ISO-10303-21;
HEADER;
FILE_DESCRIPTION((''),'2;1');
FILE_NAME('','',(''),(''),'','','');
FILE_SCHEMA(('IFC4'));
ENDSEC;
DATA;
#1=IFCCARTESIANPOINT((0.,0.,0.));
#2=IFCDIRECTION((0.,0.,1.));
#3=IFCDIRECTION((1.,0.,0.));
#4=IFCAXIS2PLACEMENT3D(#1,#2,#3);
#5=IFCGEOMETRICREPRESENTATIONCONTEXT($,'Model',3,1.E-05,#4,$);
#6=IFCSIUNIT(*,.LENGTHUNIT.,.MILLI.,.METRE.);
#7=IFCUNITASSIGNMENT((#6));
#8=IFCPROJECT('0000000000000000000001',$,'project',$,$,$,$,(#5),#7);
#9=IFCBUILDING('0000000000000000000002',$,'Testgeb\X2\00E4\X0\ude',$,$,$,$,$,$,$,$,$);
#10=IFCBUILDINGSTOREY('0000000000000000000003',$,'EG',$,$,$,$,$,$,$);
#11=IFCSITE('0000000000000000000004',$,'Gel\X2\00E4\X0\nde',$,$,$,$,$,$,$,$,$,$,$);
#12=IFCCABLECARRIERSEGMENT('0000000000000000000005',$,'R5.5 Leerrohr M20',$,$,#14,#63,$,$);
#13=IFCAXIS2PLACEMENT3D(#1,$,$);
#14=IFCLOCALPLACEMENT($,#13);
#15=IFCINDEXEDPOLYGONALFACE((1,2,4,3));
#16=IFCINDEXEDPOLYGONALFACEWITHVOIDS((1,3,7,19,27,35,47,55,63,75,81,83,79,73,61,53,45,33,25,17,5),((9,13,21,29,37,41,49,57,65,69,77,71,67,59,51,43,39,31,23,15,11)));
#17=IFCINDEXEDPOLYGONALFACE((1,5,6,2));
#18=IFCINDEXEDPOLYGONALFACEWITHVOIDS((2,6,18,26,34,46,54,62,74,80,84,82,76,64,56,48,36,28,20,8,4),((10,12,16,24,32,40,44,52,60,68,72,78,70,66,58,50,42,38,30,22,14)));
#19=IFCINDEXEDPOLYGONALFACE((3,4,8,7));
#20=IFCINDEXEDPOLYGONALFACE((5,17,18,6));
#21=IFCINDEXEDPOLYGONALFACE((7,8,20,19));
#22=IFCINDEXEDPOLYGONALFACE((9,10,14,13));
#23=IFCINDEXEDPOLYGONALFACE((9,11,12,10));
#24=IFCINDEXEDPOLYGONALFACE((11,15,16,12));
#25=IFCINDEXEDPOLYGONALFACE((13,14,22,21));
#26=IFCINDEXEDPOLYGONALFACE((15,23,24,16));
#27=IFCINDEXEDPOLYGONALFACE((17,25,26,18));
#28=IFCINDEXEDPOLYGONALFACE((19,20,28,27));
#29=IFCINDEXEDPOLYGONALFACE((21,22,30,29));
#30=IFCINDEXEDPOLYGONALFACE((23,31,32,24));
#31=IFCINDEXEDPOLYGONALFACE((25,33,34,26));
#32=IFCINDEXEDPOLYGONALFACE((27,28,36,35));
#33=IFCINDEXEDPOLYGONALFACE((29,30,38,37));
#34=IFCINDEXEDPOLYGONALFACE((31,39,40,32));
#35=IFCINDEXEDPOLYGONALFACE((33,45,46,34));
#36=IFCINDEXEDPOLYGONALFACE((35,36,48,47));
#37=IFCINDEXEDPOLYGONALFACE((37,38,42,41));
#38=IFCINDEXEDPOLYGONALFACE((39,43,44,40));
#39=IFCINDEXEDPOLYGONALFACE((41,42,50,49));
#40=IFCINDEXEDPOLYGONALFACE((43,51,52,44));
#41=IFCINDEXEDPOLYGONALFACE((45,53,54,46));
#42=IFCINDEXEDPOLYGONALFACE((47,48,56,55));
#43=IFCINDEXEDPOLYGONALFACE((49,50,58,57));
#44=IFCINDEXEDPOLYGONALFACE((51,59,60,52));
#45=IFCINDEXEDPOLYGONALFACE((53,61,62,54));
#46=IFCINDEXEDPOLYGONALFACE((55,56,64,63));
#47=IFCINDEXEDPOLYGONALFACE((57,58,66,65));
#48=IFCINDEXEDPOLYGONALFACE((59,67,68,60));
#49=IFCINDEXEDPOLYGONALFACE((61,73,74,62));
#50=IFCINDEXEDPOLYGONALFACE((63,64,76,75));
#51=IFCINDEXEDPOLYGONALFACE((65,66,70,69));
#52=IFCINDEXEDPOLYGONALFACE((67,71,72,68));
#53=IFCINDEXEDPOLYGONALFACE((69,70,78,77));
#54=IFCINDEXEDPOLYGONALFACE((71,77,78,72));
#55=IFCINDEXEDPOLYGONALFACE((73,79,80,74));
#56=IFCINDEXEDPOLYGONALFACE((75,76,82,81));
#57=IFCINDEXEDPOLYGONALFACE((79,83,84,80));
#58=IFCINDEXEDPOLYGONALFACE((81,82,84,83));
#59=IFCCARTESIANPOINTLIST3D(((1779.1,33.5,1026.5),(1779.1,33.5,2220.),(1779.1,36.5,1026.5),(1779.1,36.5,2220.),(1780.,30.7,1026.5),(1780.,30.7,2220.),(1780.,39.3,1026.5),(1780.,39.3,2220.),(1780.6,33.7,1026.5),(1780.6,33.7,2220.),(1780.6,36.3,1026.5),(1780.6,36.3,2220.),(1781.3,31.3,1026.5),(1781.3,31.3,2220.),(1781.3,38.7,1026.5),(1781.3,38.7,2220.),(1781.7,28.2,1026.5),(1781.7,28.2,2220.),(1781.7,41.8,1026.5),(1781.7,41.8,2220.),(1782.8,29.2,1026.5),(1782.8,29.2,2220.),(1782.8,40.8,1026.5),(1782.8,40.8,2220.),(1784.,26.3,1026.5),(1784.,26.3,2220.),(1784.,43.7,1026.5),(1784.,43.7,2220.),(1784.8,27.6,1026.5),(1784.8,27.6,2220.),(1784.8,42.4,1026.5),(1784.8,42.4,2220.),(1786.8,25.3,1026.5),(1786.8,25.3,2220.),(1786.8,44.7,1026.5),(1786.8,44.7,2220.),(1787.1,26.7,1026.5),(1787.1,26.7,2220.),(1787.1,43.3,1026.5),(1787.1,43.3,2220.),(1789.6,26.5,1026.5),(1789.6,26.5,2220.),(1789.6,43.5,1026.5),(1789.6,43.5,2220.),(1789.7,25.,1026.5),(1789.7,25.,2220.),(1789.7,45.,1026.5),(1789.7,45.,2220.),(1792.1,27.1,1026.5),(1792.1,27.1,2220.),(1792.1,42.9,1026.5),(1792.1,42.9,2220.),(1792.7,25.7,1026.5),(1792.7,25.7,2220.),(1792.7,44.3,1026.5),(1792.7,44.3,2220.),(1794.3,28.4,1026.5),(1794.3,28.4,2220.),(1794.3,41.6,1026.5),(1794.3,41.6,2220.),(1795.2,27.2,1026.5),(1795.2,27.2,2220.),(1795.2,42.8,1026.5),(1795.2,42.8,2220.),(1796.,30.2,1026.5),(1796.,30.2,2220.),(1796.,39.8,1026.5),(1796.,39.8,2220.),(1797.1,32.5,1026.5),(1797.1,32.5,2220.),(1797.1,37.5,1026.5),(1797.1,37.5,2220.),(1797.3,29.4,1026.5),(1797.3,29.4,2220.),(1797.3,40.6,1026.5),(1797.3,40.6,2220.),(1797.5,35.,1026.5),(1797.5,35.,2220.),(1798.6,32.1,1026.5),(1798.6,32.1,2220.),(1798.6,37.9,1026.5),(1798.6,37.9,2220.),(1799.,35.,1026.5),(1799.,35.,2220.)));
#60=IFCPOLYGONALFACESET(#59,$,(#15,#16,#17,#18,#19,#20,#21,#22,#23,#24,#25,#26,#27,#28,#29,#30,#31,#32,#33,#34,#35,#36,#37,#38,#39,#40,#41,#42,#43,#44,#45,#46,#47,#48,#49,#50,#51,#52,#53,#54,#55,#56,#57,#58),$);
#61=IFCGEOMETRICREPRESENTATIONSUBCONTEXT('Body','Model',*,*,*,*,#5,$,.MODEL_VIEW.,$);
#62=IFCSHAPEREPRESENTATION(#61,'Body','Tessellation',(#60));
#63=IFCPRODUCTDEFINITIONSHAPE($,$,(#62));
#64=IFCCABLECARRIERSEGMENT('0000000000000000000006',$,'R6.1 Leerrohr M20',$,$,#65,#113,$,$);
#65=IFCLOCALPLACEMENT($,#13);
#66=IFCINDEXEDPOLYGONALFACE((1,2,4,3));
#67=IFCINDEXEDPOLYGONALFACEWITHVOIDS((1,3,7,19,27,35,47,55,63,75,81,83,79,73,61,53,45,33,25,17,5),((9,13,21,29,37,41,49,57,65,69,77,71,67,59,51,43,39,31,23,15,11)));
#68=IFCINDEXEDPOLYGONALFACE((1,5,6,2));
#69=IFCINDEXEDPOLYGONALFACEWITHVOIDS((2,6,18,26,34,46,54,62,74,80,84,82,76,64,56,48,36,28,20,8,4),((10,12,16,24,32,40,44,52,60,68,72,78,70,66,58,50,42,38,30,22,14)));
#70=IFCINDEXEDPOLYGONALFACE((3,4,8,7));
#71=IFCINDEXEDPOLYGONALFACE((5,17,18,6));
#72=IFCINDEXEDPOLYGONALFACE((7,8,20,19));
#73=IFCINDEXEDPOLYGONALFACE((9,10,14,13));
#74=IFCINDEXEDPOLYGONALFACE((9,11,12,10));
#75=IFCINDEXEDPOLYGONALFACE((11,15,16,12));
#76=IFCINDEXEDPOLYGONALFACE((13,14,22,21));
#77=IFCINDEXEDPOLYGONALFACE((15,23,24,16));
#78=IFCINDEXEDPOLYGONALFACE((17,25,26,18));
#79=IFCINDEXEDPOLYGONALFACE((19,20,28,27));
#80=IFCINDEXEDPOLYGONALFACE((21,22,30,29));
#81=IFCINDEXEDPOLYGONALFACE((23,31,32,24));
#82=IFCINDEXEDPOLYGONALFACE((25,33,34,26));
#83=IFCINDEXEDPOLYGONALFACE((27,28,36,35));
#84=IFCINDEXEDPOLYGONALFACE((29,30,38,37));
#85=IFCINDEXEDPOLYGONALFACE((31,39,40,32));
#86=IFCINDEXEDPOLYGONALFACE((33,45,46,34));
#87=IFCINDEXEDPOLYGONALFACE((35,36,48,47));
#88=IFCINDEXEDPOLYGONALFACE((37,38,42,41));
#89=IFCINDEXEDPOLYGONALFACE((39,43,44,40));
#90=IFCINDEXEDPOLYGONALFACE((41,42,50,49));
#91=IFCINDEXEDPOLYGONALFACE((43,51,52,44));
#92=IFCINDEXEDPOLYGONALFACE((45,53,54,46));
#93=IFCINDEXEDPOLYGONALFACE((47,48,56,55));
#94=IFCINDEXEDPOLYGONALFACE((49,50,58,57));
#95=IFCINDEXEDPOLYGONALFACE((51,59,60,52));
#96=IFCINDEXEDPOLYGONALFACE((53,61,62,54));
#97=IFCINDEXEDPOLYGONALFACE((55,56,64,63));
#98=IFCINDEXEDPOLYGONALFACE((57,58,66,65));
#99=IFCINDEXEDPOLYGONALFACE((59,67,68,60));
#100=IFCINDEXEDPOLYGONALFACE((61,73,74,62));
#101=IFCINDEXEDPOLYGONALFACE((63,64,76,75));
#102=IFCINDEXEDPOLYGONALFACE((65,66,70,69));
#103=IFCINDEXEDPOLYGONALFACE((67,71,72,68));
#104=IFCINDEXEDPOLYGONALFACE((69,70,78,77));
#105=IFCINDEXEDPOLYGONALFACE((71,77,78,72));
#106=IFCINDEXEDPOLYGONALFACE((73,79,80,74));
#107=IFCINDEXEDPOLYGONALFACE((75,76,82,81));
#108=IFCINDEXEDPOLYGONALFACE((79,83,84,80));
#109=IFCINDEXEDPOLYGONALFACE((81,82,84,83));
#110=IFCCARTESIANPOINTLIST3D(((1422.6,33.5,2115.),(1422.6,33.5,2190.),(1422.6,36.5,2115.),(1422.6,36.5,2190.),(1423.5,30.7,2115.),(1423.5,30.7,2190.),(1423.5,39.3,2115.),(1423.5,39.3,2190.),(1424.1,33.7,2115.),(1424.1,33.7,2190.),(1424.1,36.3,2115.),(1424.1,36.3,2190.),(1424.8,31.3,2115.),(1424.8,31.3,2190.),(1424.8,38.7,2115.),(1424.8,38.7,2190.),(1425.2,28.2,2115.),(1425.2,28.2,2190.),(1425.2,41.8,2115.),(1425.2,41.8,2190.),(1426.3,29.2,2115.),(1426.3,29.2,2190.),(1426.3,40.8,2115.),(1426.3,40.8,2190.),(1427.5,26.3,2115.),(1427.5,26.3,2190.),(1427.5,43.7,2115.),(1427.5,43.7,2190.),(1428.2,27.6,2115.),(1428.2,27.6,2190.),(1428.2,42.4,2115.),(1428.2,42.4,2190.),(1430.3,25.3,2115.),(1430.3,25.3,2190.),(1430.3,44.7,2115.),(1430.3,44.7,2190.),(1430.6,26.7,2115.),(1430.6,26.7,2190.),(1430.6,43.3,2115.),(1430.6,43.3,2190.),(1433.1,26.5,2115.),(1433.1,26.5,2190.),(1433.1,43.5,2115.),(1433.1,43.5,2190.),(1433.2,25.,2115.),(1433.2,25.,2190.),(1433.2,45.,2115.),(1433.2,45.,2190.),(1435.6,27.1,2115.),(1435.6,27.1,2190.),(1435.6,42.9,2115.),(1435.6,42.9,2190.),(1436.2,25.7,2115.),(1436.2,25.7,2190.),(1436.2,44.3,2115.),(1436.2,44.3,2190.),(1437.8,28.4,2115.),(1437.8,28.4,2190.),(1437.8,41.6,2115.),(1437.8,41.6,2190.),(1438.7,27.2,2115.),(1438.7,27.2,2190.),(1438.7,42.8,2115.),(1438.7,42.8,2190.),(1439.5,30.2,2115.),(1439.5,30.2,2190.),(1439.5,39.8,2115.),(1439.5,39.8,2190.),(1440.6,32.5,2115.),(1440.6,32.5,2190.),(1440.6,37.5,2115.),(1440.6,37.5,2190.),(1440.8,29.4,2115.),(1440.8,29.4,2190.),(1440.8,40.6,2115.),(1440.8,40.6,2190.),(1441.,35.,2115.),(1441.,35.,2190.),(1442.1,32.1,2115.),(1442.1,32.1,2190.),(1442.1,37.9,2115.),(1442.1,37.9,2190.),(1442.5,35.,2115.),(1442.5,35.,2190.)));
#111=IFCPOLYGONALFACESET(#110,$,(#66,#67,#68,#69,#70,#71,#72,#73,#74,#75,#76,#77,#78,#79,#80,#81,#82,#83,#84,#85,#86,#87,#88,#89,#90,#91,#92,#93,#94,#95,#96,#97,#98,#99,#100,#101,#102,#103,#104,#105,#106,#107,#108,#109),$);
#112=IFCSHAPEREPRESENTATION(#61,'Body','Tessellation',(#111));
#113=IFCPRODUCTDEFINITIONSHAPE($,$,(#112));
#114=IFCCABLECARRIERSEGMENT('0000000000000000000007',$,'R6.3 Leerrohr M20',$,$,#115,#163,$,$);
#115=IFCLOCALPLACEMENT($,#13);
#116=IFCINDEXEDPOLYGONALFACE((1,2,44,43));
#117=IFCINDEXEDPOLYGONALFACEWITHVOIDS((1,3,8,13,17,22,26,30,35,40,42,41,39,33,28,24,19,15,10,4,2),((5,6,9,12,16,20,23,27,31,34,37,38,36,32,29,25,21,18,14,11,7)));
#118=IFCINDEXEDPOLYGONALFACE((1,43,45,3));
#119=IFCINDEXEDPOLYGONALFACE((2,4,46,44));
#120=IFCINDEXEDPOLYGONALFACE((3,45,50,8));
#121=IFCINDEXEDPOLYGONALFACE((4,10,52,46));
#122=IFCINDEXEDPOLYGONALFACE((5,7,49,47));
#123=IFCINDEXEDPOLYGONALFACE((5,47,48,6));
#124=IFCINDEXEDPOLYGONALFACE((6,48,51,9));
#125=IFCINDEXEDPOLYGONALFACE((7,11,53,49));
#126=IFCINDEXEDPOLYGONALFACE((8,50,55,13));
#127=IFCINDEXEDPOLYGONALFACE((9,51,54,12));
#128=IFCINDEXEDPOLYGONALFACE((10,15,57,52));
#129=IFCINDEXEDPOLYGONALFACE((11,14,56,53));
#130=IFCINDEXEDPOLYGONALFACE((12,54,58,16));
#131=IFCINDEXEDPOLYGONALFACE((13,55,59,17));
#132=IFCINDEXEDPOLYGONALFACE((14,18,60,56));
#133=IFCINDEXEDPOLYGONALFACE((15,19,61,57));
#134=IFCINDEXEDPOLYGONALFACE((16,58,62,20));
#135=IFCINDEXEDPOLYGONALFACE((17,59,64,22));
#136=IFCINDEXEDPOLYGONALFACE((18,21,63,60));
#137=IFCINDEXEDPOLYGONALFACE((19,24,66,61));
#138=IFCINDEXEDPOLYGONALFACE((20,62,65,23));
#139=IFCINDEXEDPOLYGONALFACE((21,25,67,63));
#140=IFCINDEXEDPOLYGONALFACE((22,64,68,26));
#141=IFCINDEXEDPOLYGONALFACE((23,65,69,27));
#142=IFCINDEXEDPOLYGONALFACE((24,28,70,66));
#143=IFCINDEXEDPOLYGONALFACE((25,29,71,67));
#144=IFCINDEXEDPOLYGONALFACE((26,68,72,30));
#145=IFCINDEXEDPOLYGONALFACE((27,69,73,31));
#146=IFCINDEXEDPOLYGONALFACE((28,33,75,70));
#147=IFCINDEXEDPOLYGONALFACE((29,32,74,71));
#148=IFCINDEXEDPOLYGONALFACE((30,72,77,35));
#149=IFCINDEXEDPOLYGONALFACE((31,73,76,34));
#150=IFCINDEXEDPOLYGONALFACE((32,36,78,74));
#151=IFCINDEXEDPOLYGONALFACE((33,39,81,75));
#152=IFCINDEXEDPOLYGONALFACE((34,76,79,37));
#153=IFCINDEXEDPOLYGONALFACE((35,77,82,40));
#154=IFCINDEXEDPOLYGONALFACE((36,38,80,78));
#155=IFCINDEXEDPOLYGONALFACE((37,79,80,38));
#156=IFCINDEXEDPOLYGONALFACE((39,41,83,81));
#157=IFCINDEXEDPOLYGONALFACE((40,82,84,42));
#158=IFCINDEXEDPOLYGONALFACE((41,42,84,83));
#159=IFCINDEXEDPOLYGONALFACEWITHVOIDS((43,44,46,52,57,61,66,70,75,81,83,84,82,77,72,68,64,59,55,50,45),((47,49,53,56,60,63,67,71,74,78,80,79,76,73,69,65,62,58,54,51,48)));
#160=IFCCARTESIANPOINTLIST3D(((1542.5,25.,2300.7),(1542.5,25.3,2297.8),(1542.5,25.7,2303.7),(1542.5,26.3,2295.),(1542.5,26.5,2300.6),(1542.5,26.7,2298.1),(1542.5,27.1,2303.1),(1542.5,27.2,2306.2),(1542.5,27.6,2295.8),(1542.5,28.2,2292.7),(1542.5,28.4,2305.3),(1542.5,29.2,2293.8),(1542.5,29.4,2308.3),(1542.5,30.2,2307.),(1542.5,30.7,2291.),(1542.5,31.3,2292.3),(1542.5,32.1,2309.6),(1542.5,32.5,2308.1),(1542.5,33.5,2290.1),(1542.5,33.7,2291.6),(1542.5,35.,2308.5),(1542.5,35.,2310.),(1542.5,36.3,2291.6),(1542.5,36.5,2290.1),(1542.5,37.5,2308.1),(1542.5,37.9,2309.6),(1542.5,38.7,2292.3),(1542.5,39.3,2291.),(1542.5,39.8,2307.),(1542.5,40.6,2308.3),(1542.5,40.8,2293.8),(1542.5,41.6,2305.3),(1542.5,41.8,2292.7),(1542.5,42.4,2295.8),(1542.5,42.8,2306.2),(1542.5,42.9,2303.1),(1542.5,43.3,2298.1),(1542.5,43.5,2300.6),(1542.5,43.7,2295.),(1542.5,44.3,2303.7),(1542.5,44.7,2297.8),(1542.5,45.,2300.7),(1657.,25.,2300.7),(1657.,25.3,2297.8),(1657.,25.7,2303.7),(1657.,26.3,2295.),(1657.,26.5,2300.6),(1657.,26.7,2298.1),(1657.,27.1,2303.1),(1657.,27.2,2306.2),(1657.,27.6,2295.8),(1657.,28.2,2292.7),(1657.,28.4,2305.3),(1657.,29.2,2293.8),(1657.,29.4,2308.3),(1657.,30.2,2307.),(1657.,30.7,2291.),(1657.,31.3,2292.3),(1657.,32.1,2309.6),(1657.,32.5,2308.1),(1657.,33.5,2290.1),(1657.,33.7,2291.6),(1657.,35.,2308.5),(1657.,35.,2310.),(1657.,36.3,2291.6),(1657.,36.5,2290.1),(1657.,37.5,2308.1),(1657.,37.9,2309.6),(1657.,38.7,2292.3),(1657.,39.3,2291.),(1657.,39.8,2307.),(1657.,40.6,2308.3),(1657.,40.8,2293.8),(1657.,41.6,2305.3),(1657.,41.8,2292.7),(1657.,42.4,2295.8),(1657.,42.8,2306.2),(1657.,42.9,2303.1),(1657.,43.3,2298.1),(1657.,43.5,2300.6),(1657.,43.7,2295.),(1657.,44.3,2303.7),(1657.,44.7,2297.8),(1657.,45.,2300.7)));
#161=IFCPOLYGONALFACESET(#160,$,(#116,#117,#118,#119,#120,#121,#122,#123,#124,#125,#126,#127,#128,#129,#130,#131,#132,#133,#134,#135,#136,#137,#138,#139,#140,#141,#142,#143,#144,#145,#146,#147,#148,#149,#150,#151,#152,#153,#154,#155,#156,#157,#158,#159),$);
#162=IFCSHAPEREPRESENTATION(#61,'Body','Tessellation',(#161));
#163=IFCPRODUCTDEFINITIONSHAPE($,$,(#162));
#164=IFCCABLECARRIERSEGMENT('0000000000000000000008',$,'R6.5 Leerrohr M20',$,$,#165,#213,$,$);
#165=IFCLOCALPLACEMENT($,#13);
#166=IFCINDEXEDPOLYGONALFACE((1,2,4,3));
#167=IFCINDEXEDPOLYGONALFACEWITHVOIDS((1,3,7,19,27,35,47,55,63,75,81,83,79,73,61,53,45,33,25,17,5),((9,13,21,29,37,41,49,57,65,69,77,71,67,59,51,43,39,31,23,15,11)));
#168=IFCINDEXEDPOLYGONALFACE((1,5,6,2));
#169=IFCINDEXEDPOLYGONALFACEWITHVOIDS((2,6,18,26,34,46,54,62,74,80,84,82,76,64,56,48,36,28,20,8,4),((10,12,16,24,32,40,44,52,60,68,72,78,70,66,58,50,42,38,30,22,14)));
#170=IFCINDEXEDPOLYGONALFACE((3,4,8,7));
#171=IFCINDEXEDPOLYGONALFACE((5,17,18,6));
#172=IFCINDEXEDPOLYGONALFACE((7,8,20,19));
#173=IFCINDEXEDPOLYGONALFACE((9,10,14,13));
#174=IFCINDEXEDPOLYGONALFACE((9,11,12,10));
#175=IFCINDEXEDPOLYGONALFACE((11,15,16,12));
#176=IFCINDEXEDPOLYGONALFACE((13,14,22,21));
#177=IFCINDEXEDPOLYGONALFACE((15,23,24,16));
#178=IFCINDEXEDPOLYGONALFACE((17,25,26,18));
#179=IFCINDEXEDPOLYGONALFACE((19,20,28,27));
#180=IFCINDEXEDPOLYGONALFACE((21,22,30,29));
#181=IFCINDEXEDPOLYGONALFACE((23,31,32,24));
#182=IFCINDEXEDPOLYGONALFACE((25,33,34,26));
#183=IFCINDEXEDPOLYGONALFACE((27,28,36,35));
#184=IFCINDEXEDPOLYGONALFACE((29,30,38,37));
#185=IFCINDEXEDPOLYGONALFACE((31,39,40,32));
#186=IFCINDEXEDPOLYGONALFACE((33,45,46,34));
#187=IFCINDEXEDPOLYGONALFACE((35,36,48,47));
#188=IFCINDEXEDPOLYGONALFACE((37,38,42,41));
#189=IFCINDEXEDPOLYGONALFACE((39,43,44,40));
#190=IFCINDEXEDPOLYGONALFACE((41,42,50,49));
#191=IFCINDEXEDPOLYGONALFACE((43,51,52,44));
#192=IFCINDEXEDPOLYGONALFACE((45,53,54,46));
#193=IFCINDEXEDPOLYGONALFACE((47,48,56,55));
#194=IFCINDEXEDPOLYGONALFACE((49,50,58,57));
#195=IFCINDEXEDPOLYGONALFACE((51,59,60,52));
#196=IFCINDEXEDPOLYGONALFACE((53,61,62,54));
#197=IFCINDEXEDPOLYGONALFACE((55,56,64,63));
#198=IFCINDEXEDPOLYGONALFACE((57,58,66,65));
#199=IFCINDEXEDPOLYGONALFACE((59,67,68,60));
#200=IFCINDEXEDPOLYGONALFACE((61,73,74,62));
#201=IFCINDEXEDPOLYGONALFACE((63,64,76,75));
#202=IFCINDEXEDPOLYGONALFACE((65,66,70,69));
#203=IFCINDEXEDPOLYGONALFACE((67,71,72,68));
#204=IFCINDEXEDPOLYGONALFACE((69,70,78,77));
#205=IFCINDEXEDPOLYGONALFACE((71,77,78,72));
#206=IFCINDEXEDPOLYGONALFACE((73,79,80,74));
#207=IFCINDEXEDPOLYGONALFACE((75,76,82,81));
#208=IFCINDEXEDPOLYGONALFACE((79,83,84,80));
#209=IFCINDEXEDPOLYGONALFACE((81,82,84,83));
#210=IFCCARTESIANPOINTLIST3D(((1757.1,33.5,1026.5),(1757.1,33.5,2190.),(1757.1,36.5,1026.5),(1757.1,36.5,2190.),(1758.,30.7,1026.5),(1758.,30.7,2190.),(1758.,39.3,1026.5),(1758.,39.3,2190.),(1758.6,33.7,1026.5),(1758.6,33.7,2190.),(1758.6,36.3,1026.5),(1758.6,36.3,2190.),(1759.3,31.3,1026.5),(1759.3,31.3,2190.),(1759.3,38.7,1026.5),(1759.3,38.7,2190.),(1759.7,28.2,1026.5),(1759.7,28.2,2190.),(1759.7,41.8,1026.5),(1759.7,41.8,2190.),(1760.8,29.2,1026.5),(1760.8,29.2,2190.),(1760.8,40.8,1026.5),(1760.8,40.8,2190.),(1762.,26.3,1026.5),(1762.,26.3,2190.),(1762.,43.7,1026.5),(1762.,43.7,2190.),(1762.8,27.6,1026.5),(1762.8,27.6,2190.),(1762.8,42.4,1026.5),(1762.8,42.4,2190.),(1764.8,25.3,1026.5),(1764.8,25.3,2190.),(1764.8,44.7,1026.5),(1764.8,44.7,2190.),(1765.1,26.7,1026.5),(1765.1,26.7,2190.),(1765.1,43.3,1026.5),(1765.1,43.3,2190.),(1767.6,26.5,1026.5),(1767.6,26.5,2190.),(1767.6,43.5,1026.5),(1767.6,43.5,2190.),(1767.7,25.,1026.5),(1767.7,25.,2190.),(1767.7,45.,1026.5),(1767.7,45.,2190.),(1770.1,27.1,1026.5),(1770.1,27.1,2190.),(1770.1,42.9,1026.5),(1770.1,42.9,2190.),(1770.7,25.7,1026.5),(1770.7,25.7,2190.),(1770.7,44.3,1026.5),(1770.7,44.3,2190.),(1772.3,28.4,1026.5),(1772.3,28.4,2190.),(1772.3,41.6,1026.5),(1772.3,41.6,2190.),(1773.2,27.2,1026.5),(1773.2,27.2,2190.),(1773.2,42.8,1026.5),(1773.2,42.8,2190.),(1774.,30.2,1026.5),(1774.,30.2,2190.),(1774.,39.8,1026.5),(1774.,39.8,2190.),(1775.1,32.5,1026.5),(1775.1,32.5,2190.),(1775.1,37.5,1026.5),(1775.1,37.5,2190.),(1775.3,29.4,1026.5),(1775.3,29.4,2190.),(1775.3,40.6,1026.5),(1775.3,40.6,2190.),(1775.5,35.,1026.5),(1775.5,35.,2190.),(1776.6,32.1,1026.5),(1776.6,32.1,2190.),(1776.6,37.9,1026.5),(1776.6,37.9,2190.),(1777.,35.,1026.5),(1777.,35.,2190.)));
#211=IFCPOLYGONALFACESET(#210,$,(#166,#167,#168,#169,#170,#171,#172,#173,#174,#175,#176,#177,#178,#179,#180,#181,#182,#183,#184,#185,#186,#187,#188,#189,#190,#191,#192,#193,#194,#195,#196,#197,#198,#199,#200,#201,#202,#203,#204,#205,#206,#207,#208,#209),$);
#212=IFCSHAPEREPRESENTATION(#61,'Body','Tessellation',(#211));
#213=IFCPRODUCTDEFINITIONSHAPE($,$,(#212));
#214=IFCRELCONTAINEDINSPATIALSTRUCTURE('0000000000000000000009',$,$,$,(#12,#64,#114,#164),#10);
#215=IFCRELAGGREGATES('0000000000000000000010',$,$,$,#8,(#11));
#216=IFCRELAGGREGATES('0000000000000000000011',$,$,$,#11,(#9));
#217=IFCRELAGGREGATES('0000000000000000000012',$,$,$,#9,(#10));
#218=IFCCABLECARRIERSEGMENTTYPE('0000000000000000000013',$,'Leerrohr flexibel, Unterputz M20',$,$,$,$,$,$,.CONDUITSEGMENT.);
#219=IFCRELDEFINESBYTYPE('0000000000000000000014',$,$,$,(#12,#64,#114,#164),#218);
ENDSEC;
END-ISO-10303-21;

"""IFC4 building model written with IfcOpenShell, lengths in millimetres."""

from ifc_helpers import new_model, si_unit, frame, origin_with_axes, place, context, subcontext, project, spatial, hollow_circle, extrude, type_object, element, save


model = new_model("IFC4")

# Units and contexts
model_context = context("Model", 3, precision=1e-05, world=origin_with_axes())
body_context = subcontext(model_context, "Body", "Model", "MODEL_VIEW")
ifc_project = project(units=[si_unit("LENGTHUNIT", "METRE", prefix="MILLI")], contexts=[model_context])

# Site, building, storey
site = spatial("IfcSite", under=ifc_project, Name="Gelände")
building = spatial("IfcBuilding", under=site, Name="Testgebäude")
storey = spatial("IfcBuildingStorey", under=building, Name="EG")

# Cable carrier segments
cable_carrier_segment_type_1 = type_object("IfcCableCarrierSegmentType", Name="Leerrohr flexibel, Unterputz M20", PredefinedType="CONDUITSEGMENT")
cable_carrier_segment_1_placement = place(None, frame((1789.0, 35.0, 2220.0), z_axis=(0.0, 0.0, -1.0), x_axis=(1.0, 0.0, 0.0)))
element("IfcCableCarrierSegment", 1, at=cable_carrier_segment_1_placement, inside=storey, type_object=cable_carrier_segment_type_1, Name="R5.5 Leerrohr M20", context=body_context, shape_type="SweptSolid", body=[
    extrude(hollow_circle(Radius=10.0, WallThickness=1.5), None, (0.0, 0.0, 1.0), 1193.5),
])
cable_carrier_segment_2_placement = place(None, frame((1432.5, 35.0, 2115.0), z_axis=(0.0, 0.0, 1.0), x_axis=(1.0, 0.0, 0.0)))
element("IfcCableCarrierSegment", 2, at=cable_carrier_segment_2_placement, inside=storey, type_object=cable_carrier_segment_type_1, Name="R6.1 Leerrohr M20", context=body_context, shape_type="SweptSolid", body=[
    extrude(hollow_circle(Radius=10.0, WallThickness=1.5), None, (0.0, 0.0, 1.0), 75.0),
])
cable_carrier_segment_3_placement = place(None, frame((1542.5, 35.0, 2300.0), z_axis=(1.0, 0.0, 0.0), x_axis=(0.0, 0.0, 1.0)))
element("IfcCableCarrierSegment", 3, at=cable_carrier_segment_3_placement, inside=storey, type_object=cable_carrier_segment_type_1, Name="R6.3 Leerrohr M20", context=body_context, shape_type="SweptSolid", body=[
    extrude(hollow_circle(Radius=10.0, WallThickness=1.5), None, (0.0, 0.0, 1.0), 114.5),
])
cable_carrier_segment_4_placement = place(None, frame((1767.0, 35.0, 2190.0), z_axis=(0.0, 0.0, -1.0), x_axis=(1.0, 0.0, 0.0)))
element("IfcCableCarrierSegment", 4, at=cable_carrier_segment_4_placement, inside=storey, type_object=cable_carrier_segment_type_1, Name="R6.5 Leerrohr M20", context=body_context, shape_type="SweptSolid", body=[
    extrude(hollow_circle(Radius=10.0, WallThickness=1.5), None, (0.0, 0.0, 1.0), 1163.5),
])

save(model, "model.ifc")
